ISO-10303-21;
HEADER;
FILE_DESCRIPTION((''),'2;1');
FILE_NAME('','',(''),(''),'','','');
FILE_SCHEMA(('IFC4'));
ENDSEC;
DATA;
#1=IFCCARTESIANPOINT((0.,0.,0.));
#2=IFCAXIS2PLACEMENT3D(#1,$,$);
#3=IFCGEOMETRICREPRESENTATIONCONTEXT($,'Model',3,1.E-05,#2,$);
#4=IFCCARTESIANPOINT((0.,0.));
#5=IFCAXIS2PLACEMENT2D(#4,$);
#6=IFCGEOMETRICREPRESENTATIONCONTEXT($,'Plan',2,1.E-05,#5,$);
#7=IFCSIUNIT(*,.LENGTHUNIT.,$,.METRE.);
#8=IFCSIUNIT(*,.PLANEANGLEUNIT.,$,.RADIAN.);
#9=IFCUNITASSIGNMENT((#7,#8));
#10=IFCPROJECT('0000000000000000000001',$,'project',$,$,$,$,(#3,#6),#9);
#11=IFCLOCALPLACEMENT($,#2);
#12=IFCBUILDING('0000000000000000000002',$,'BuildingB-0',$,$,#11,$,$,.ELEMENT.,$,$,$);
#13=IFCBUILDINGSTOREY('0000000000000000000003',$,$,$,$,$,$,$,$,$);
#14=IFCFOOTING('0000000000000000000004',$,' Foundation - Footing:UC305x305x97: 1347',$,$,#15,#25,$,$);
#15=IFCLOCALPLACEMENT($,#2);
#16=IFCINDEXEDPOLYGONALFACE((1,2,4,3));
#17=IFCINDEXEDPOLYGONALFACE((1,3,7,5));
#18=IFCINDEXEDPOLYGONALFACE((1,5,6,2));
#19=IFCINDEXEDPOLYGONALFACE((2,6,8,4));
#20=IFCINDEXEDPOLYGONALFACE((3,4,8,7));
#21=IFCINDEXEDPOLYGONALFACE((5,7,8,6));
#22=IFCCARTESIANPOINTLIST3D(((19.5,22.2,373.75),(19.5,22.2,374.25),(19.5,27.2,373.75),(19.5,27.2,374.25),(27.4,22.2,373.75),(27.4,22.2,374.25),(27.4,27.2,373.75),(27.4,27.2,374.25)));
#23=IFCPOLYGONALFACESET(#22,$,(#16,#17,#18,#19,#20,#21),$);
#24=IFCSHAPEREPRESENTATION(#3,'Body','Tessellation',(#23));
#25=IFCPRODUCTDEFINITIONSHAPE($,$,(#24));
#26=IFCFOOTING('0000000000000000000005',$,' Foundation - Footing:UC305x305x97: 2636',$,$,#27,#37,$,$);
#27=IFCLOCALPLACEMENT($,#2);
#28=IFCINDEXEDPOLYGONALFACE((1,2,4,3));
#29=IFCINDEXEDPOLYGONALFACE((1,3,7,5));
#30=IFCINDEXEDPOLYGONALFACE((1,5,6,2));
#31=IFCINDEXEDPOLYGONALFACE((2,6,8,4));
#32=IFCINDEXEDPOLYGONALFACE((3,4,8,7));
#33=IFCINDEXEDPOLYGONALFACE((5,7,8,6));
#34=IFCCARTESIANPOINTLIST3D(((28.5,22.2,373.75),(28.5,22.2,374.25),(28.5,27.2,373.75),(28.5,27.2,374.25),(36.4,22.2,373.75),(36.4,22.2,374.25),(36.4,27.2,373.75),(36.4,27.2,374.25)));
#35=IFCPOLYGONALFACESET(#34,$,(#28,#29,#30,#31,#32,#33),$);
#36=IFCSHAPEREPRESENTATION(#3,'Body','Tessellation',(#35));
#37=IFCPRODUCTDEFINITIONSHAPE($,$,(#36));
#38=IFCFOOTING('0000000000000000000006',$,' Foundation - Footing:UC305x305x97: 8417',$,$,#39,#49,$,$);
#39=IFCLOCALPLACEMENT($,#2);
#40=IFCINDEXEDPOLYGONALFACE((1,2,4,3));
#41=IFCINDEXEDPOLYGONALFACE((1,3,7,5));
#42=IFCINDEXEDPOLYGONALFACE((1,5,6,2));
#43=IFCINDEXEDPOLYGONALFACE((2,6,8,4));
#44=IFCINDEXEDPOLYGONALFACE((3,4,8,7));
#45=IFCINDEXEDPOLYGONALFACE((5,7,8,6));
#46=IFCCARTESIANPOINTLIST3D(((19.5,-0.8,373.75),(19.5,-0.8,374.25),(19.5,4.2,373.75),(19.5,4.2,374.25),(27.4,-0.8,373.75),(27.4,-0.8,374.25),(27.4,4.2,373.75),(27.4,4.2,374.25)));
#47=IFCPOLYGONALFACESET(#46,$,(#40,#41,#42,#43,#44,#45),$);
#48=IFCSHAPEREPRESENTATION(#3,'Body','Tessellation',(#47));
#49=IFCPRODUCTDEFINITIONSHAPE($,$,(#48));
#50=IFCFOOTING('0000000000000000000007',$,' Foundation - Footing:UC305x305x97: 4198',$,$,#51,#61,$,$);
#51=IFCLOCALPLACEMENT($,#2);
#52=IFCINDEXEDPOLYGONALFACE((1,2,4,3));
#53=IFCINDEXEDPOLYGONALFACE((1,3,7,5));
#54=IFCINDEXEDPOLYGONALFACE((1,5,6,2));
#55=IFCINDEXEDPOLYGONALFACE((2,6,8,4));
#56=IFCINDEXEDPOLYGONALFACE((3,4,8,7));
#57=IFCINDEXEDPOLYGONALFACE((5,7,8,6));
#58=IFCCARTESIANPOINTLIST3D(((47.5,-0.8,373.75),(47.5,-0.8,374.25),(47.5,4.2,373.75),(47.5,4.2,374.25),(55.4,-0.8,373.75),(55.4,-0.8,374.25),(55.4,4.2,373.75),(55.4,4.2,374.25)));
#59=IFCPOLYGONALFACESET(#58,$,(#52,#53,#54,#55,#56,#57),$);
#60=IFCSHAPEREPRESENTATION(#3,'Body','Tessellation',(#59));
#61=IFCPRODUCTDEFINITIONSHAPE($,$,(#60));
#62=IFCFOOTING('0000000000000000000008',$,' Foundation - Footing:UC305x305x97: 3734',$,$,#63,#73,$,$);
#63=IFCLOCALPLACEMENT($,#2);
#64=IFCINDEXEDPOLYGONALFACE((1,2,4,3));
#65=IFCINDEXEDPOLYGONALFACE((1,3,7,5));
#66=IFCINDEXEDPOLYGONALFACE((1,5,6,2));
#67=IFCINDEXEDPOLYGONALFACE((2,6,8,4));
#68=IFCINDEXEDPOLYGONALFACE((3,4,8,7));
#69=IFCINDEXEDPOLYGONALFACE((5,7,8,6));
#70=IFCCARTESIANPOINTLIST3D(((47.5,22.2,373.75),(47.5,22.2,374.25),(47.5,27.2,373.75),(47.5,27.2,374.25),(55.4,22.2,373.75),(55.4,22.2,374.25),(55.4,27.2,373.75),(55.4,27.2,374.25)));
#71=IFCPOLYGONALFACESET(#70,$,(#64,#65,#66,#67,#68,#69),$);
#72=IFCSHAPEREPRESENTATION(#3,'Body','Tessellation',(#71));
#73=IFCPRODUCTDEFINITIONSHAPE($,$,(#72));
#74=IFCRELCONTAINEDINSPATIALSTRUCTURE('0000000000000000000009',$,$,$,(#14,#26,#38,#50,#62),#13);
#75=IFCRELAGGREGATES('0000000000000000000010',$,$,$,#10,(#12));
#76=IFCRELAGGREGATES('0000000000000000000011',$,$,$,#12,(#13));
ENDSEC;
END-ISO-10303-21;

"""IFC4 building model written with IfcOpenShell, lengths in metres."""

from ifc_helpers import new_model, si_unit, origin, origin_2d, place, context, project, spatial, polyline, outline, extrude, element, save


model = new_model("IFC4")

# Units and contexts
model_context = context("Model", 3, precision=1e-05, world=origin())
plan_context = context("Plan", 2, precision=1e-05, world=origin_2d())
ifc_project = project(units=[si_unit("LENGTHUNIT", "METRE"), si_unit("PLANEANGLEUNIT", "RADIAN")], contexts=[model_context, plan_context])

# Building, storey
building_placement = place(None, origin())
building = spatial("IfcBuilding", under=ifc_project, at=building_placement, Name="BuildingB-0", CompositionType="ELEMENT")
storey = spatial("IfcBuildingStorey", under=building)

# Footings
element("IfcFooting", 1, inside=storey, Name=" Foundation - Footing:UC305x305x97: 1347", context=model_context, shape_type="SweptSolid", body=[
    extrude(outline(polyline([(27.4, 27.2, 373.75), (19.5, 27.2, 373.75), (19.5, 22.2, 373.75), (27.4, 22.2, 373.75), (27.4, 27.2, 373.75)])), None, (0.0, 0.0, 1.0), 0.5),
])
element("IfcFooting", 2, inside=storey, Name=" Foundation - Footing:UC305x305x97: 2636", context=model_context, shape_type="SweptSolid", body=[
    extrude(outline(polyline([(36.4, 27.2, 373.75), (28.5, 27.2, 373.75), (28.5, 22.2, 373.75), (36.4, 22.2, 373.75), (36.4, 27.2, 373.75)])), None, (0.0, 0.0, 1.0), 0.5),
])
element("IfcFooting", 3, inside=storey, Name=" Foundation - Footing:UC305x305x97: 8417", context=model_context, shape_type="SweptSolid", body=[
    extrude(outline(polyline([(27.4, 4.2, 373.75), (19.5, 4.2, 373.75), (19.5, -0.8, 373.75), (27.4, -0.8, 373.75), (27.4, 4.2, 373.75)])), None, (0.0, 0.0, 1.0), 0.5),
])
element("IfcFooting", 4, inside=storey, Name=" Foundation - Footing:UC305x305x97: 4198", context=model_context, shape_type="SweptSolid", body=[
    extrude(outline(polyline([(55.4, 4.2, 373.75), (47.5, 4.2, 373.75), (47.5, -0.8, 373.75), (55.4, -0.8, 373.75), (55.4, 4.2, 373.75)])), None, (0.0, 0.0, 1.0), 0.5),
])
element("IfcFooting", 5, inside=storey, Name=" Foundation - Footing:UC305x305x97: 3734", context=model_context, shape_type="SweptSolid", body=[
    extrude(outline(polyline([(55.4, 27.2, 373.75), (47.5, 27.2, 373.75), (47.5, 22.2, 373.75), (55.4, 22.2, 373.75), (55.4, 27.2, 373.75)])), None, (0.0, 0.0, 1.0), 0.5),
])

save(model, "model.ifc")
